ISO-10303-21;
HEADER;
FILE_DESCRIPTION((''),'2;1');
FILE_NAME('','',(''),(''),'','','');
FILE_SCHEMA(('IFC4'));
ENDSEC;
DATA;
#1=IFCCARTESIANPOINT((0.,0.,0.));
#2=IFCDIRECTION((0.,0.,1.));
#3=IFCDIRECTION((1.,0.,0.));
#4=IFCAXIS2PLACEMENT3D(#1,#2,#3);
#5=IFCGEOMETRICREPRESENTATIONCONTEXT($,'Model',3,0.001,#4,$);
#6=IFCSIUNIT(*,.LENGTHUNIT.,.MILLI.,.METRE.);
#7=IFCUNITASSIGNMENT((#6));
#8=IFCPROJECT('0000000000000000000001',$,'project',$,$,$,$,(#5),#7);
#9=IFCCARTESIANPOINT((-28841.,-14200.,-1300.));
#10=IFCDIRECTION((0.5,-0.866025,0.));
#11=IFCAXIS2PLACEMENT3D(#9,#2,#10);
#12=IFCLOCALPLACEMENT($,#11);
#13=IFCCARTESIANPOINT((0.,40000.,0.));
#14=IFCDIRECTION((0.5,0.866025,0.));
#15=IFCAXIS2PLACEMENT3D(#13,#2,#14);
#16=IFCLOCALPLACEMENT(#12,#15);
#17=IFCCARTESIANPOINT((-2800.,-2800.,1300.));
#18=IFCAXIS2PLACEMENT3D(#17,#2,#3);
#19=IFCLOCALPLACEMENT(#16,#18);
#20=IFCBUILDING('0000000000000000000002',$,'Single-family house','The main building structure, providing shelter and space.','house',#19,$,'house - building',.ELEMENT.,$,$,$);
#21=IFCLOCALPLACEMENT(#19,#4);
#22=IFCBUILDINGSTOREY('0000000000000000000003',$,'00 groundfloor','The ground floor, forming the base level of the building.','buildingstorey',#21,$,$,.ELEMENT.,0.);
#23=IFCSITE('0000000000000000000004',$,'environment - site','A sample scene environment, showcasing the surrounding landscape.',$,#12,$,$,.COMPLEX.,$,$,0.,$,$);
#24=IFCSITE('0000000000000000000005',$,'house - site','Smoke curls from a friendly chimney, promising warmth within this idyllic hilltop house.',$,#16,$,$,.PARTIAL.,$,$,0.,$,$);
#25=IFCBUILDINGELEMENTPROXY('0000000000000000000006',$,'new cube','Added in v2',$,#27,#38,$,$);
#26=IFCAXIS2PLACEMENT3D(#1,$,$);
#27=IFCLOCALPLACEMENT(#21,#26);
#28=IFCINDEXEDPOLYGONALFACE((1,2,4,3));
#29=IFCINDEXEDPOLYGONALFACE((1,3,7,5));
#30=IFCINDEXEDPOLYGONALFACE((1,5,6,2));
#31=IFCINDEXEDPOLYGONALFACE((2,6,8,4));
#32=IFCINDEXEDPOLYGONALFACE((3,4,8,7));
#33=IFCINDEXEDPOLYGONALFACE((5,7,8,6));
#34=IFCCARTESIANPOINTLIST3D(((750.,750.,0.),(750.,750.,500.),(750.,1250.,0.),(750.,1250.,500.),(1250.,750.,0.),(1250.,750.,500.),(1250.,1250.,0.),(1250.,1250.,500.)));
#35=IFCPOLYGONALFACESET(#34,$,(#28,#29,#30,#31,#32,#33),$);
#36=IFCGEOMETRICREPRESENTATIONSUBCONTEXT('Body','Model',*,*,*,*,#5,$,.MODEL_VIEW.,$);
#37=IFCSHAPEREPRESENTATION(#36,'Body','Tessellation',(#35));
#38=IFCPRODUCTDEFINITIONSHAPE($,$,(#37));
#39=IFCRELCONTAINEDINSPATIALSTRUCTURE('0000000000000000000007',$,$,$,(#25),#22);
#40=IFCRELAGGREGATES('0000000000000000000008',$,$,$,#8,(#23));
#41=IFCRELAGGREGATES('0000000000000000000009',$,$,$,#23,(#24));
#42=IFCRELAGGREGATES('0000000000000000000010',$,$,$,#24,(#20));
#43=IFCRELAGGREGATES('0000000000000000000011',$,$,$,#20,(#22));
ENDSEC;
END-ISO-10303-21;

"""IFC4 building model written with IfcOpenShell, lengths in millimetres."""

from ifc_helpers import new_model, si_unit, frame, origin, origin_with_axes, origin_2d, place, context, subcontext, project, spatial, rectangle, extrude, element, save


model = new_model("IFC4")

# Units and contexts
model_context = context("Model", 3, precision=0.001, world=origin_with_axes())
body_context = subcontext(model_context, "Body", "Model", "MODEL_VIEW")
ifc_project = project(units=[si_unit("LENGTHUNIT", "METRE", prefix="MILLI")], contexts=[model_context])

# Sites, building, storey
site_1_placement = place(None, frame((-28841.0, -14200.0, -1300.0), z_axis=(0.0, 0.0, 1.0), x_axis=(0.5, -0.866025, 0.0)))
site_1 = spatial("IfcSite", under=ifc_project, at=site_1_placement, Name="environment - site", Description="A sample scene environment, showcasing the surrounding landscape.", CompositionType="COMPLEX", RefElevation=0.0)
site_2_placement = place(site_1_placement, frame((0.0, 40000.0, 0.0), z_axis=(0.0, 0.0, 1.0), x_axis=(0.5, 0.866025, 0.0)))
site_2 = spatial("IfcSite", under=site_1, at=site_2_placement, Name="house - site", Description="Smoke curls from a friendly chimney, promising warmth within this idyllic hilltop house.", CompositionType="PARTIAL", RefElevation=0.0)
building_placement = place(site_2_placement, frame((-2800.0, -2800.0, 1300.0), z_axis=(0.0, 0.0, 1.0), x_axis=(1.0, 0.0, 0.0)))
building = spatial("IfcBuilding", under=site_2, at=building_placement, Name="Single-family house", Description="The main building structure, providing shelter and space.", ObjectType="house", LongName="house - building", CompositionType="ELEMENT")
storey_placement = place(building_placement, origin_with_axes())
storey = spatial("IfcBuildingStorey", under=building, at=storey_placement, Name="00 groundfloor", Description="The ground floor, forming the base level of the building.", ObjectType="buildingstorey", CompositionType="ELEMENT", Elevation=0.0)

# Building element proxy
proxy_placement = place(storey_placement, frame((1000.0, 1000.0, 0.0)))
element("IfcBuildingElementProxy", 1, at=proxy_placement, inside=storey, Name="new cube", Description="Added in v2", context=body_context, shape_type="SweptSolid", body=[
    extrude(rectangle(XDim=500.0, YDim=500.0, at=origin_2d()), origin(), (0.0, 0.0, 1.0), 500.0),
])

save(model, "model.ifc")
